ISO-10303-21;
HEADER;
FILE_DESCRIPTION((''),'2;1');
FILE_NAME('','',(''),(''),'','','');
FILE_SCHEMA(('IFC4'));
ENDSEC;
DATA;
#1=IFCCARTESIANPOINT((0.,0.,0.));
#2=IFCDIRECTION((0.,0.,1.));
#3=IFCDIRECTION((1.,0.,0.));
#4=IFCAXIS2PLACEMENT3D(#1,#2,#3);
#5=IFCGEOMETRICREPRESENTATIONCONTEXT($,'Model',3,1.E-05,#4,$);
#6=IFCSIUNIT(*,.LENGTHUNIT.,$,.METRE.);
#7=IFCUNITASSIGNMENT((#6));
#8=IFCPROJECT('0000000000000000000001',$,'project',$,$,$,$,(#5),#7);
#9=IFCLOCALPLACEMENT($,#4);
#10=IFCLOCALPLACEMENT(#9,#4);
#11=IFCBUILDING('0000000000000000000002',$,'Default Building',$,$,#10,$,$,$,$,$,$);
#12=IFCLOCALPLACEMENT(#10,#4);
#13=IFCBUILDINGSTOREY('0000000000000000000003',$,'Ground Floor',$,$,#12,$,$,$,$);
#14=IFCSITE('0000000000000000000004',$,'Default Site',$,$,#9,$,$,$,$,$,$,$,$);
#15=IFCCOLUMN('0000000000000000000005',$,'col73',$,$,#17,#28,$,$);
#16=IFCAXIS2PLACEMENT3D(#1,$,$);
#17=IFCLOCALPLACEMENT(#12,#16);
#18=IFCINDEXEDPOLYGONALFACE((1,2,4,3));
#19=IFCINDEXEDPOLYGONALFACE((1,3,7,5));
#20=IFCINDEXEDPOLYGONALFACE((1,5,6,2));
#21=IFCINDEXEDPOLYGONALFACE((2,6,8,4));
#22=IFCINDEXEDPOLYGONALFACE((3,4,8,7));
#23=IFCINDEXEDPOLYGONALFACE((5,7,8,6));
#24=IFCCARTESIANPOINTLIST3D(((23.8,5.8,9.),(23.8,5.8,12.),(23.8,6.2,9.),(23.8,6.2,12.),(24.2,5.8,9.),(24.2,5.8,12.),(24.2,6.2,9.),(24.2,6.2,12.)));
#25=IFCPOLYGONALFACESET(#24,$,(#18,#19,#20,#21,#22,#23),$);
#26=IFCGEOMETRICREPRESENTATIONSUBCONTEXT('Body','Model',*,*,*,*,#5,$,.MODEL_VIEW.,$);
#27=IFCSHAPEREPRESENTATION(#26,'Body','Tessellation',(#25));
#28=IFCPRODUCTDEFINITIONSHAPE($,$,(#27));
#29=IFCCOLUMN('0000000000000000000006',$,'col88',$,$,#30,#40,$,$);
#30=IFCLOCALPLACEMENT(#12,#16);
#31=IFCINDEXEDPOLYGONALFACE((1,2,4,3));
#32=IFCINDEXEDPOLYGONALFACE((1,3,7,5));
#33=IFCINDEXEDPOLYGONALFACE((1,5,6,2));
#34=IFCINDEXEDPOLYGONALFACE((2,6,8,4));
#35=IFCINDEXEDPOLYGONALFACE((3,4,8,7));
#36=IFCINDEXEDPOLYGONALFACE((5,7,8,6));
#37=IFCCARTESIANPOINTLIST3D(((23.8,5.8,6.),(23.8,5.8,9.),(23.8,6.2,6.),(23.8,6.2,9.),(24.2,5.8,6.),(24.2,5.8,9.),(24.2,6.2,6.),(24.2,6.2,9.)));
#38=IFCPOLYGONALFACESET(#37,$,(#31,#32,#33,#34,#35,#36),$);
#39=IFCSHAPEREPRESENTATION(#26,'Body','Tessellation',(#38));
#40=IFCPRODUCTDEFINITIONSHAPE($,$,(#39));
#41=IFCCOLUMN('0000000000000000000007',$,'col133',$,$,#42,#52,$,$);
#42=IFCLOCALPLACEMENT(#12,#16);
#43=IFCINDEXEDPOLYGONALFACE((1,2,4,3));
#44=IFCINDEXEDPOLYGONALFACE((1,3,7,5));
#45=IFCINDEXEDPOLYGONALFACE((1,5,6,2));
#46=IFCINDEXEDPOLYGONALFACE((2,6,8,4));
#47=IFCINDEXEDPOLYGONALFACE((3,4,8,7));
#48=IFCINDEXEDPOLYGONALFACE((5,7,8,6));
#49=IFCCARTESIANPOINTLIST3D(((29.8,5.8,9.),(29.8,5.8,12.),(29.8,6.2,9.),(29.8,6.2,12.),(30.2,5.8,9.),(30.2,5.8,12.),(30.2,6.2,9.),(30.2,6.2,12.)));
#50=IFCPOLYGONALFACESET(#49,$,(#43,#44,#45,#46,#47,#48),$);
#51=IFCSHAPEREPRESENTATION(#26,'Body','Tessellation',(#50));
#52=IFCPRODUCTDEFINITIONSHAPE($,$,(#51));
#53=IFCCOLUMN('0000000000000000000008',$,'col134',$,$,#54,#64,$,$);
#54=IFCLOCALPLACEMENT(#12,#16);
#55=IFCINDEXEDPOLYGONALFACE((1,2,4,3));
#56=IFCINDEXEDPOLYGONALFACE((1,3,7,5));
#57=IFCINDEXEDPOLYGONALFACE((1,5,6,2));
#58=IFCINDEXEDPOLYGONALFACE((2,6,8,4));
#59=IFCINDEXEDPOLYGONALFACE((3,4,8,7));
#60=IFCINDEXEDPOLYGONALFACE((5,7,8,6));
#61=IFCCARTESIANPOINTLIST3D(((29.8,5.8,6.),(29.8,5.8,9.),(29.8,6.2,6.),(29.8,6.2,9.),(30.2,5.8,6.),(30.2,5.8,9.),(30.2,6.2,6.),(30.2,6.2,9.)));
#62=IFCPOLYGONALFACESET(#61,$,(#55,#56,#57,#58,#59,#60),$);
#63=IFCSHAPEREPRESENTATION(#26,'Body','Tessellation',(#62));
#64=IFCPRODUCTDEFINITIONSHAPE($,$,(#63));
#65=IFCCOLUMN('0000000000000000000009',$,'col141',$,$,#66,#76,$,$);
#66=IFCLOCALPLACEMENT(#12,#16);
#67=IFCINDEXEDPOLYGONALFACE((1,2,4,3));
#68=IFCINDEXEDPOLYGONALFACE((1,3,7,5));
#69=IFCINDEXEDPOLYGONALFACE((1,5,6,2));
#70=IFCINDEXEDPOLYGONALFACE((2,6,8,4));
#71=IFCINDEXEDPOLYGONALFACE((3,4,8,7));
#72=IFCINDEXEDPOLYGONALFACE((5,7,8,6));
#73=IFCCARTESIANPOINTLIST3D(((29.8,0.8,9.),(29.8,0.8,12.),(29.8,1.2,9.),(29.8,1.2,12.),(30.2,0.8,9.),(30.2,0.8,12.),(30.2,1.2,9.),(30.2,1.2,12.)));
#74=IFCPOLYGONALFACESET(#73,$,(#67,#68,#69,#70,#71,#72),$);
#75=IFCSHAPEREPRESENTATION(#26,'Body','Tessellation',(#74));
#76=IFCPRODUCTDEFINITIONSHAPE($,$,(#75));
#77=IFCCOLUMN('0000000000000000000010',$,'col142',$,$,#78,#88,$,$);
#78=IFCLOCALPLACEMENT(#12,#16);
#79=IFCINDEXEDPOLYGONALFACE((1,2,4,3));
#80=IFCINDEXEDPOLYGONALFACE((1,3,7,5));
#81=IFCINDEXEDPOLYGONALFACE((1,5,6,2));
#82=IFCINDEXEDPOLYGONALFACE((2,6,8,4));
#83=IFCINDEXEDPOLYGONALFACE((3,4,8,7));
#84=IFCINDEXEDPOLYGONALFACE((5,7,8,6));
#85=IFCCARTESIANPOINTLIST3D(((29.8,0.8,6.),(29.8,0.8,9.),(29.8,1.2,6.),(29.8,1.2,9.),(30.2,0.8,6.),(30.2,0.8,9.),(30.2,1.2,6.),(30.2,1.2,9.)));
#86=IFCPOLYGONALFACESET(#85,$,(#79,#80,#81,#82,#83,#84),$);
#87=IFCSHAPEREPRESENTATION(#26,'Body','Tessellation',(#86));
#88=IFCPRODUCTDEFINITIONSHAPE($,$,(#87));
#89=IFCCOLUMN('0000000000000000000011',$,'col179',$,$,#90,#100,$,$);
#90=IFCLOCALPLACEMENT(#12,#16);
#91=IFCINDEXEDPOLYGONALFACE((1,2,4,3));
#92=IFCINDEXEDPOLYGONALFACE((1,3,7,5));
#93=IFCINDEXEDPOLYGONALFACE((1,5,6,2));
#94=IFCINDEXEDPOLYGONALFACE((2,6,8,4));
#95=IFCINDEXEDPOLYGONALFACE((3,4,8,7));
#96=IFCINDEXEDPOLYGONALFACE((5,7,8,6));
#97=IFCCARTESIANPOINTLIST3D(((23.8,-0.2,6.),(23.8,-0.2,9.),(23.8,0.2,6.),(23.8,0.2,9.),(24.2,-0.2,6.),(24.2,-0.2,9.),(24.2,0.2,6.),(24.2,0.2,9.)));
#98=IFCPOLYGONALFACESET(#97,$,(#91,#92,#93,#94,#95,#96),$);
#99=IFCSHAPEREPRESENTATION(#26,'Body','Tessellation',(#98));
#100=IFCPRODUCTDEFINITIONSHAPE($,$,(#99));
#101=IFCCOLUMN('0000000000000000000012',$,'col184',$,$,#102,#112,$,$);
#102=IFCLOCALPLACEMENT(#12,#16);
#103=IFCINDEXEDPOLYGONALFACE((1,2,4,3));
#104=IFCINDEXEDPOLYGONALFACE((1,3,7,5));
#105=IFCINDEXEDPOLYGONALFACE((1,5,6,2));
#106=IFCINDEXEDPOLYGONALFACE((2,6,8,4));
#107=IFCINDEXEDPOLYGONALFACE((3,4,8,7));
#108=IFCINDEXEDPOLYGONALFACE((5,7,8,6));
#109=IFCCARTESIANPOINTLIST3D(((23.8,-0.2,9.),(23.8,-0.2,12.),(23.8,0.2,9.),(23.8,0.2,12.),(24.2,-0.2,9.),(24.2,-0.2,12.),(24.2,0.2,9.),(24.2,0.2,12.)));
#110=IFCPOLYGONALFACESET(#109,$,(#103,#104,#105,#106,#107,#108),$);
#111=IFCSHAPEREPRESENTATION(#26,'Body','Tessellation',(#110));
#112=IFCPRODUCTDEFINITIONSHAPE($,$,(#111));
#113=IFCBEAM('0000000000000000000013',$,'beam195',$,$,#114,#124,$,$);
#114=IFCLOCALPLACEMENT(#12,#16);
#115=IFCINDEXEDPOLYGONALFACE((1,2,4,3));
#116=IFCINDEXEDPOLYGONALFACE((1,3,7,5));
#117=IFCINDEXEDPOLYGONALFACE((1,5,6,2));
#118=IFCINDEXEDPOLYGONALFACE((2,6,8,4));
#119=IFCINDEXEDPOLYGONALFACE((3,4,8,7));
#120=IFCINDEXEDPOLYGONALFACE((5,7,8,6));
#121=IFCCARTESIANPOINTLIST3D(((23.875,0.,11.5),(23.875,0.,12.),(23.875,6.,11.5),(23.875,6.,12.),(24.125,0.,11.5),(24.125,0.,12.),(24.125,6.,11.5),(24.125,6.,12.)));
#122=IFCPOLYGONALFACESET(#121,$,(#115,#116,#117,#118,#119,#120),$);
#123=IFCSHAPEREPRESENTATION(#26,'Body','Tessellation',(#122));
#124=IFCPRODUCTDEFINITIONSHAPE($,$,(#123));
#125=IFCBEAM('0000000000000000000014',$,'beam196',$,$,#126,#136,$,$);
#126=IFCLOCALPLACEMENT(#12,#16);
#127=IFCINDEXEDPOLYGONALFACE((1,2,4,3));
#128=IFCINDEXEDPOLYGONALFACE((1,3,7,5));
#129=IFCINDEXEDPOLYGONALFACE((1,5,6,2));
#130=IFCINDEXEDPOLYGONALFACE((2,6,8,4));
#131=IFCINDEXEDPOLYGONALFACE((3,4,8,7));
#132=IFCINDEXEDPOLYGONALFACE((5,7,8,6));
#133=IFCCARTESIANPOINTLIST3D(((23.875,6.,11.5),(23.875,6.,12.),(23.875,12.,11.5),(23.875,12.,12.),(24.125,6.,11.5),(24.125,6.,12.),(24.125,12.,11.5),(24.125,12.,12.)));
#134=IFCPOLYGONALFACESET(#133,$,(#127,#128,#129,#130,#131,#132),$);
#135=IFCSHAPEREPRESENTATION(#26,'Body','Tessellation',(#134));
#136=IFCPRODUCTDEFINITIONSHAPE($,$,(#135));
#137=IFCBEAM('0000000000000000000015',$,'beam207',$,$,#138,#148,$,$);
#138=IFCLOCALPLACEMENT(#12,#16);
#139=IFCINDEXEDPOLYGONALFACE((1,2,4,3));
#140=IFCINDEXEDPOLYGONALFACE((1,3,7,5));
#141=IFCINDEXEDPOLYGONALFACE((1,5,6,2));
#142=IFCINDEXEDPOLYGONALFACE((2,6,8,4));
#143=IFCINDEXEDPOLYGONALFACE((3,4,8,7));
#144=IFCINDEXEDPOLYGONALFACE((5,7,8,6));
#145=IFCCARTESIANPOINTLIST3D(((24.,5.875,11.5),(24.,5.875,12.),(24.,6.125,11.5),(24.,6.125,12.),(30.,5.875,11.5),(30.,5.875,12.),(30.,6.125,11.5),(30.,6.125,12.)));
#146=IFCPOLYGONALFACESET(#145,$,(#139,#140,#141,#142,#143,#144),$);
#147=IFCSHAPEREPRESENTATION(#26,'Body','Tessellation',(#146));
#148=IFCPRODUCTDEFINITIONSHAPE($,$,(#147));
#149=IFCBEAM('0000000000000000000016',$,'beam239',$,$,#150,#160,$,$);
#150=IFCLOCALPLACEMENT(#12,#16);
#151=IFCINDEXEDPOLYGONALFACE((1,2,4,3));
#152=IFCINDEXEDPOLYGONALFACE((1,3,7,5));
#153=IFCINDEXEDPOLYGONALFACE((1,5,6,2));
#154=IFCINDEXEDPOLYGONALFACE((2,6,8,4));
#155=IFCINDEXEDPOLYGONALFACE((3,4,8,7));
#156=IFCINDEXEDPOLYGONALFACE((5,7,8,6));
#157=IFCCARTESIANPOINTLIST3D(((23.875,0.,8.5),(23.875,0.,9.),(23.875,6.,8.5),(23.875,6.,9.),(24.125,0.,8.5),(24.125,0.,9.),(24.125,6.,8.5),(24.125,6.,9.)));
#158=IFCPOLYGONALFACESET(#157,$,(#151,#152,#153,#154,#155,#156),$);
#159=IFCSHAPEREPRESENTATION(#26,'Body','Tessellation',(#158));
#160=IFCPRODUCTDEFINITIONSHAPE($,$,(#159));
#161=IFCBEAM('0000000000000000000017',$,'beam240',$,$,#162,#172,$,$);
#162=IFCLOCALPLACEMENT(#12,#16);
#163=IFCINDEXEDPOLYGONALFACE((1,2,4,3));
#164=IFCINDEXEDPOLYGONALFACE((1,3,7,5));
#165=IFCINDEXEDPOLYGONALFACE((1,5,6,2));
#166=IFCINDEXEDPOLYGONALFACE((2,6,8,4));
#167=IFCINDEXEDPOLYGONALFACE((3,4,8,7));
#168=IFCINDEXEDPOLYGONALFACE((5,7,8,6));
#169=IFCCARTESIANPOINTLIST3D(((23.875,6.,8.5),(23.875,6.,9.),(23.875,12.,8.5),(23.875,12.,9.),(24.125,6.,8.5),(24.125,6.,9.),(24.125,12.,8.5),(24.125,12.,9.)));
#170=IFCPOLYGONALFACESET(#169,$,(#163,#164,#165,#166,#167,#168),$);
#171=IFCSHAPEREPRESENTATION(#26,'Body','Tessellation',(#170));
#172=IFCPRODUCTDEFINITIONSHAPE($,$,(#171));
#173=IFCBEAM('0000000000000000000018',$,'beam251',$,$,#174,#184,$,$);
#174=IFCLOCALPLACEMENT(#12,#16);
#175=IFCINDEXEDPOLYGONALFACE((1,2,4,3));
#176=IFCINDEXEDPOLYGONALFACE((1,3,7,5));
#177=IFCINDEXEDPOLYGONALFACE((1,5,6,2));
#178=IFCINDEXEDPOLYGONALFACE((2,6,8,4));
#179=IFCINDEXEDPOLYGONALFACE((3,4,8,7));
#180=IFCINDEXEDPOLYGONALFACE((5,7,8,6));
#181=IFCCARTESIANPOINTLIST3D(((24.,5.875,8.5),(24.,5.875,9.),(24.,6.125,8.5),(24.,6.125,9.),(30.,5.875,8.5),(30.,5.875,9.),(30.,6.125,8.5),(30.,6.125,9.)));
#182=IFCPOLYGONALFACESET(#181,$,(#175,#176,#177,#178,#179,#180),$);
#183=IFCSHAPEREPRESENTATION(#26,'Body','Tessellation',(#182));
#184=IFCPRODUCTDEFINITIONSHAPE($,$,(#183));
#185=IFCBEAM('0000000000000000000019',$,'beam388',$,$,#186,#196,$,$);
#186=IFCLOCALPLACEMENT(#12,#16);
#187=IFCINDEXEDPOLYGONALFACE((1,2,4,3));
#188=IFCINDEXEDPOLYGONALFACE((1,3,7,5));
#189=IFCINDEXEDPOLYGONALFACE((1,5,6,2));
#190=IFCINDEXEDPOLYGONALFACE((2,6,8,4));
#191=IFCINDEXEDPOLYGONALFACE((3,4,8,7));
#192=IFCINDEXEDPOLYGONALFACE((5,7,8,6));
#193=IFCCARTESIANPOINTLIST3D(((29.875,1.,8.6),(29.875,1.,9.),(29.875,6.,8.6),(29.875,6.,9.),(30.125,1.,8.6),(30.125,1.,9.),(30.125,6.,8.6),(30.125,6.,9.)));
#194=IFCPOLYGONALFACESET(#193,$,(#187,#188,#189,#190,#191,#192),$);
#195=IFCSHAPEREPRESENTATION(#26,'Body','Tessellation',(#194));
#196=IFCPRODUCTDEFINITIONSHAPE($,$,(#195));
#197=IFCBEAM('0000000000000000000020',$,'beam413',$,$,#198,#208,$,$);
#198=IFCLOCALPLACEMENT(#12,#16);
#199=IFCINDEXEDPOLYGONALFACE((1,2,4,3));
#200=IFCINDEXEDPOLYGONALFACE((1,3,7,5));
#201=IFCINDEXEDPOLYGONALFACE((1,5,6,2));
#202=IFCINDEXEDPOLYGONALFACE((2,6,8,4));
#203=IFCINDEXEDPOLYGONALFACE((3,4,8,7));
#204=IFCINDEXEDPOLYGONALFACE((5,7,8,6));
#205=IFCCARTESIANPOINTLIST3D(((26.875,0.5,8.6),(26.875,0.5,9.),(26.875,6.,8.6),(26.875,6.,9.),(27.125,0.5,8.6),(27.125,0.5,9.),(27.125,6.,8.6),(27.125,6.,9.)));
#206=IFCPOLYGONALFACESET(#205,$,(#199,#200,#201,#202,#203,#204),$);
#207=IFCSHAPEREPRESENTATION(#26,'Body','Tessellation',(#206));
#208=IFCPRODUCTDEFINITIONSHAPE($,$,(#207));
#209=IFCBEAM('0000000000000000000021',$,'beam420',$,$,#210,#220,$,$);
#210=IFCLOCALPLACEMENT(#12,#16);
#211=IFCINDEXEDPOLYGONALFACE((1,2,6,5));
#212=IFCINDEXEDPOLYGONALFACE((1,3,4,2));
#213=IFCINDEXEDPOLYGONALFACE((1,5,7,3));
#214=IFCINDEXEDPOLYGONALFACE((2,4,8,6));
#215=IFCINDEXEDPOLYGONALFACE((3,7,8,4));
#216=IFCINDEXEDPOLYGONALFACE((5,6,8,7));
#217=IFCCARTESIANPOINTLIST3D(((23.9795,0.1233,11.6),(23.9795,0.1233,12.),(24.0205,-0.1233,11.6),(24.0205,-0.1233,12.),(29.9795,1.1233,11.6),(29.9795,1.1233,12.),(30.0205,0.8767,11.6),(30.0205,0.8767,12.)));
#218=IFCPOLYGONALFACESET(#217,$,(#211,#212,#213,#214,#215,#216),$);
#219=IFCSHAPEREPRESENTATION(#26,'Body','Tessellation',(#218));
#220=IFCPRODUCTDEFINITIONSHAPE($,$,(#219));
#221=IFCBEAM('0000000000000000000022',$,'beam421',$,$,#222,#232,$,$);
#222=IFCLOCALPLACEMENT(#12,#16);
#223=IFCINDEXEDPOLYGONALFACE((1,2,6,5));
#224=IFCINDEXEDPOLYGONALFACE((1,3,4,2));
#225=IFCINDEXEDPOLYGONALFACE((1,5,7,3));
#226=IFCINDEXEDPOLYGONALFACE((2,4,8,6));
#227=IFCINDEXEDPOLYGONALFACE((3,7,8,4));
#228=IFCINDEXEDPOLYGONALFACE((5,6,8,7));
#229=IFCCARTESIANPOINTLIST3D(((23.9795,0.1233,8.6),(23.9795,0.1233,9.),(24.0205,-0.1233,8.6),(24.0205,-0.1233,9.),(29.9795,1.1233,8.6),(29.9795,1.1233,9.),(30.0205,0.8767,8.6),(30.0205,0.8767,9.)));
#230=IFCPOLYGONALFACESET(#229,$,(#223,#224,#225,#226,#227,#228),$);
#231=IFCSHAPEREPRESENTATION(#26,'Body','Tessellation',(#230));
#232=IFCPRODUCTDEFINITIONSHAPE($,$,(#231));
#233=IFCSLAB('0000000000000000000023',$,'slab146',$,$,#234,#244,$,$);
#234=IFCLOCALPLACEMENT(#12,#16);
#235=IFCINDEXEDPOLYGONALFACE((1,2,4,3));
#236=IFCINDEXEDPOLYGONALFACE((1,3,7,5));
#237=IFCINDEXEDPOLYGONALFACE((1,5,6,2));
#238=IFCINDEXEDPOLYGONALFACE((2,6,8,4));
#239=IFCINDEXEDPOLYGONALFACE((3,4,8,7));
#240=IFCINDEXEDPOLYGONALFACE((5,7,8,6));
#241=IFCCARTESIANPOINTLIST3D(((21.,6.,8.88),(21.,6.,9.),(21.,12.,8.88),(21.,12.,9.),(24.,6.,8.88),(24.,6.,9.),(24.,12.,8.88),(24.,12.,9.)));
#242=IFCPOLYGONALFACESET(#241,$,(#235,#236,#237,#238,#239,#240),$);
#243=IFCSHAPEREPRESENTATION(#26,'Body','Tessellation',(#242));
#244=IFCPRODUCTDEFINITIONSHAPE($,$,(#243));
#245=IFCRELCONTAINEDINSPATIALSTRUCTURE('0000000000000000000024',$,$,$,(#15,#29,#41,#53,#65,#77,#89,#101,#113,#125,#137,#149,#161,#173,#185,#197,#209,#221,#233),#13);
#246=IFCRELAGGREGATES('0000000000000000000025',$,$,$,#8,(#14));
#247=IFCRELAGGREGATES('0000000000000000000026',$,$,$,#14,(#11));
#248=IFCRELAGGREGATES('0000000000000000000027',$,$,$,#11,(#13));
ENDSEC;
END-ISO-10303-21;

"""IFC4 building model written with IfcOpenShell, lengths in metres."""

from ifc_helpers import new_model, si_unit, frame, origin_with_axes, place, context, subcontext, project, spatial, indexed_curve, outline, extrude, element, save


model = new_model("IFC4")

# Units and contexts
model_context = context("Model", 3, precision=1e-05, world=origin_with_axes())
body_context = subcontext(model_context, "Body", "Model", "MODEL_VIEW")
ifc_project = project(units=[si_unit("LENGTHUNIT", "METRE")], contexts=[model_context])

# Site, building, storey
site_placement = place(None, origin_with_axes())
site = spatial("IfcSite", under=ifc_project, at=site_placement, Name="Default Site")
building_placement = place(site_placement, origin_with_axes())
building = spatial("IfcBuilding", under=site, at=building_placement, Name="Default Building")
storey_placement = place(building_placement, origin_with_axes())
storey = spatial("IfcBuildingStorey", under=building, at=storey_placement, Name="Ground Floor")

# Columns
for number, where, z_axis, x_axis, name in (
    (1, (23.8, 5.8, 9.0), (0.0, 0.0, 1.0), (1.0, 0.0, 0.0), "col73"),
    (2, (23.8, 5.8, 6.0), (0.0, 0.0, 1.0), (1.0, 0.0, 0.0), "col88"),
    (3, (29.8, 5.8, 9.0), (0.0, 0.0, 1.0), (1.0, 0.0, 0.0), "col133"),
    (4, (29.8, 5.8, 6.0), (0.0, 0.0, 1.0), (1.0, 0.0, 0.0), "col134"),
    (5, (29.8, 0.8, 9.0), (0.0, 0.0, 1.0), (1.0, 0.0, 0.0), "col141"),
    (6, (29.8, 0.8, 6.0), (0.0, 0.0, 1.0), (1.0, 0.0, 0.0), "col142"),
    (7, (23.8, -0.2, 6.0), (0.0, 0.0, 1.0), (1.0, 0.0, 0.0), "col179"),
    (8, (23.8, -0.2, 9.0), (0.0, 0.0, 1.0), (1.0, 0.0, 0.0), "col184"),
):
    element("IfcColumn", number, at=place(storey_placement, frame(where, z_axis=z_axis, x_axis=x_axis)), inside=storey, Name=name, context=body_context, shape_type="SweptSolid", body=[
        extrude(outline(indexed_curve([(0.0, 0.0), (0.0, 0.4), (0.4, 0.4), (0.4, 0.0), (0.0, 0.0)], self_intersect=False)), origin_with_axes(), (0.0, 0.0, 1.0), 3.0),
    ])

# Beams
for number, where, z_axis, x_axis, name in (
    (9, (24.125, 0.0, 11.5), (0.0, 0.0, 1.0), (0.0, 1.0, 0.0), "beam195"),
    (10, (24.125, 6.0, 11.5), (0.0, 0.0, 1.0), (0.0, 1.0, 0.0), "beam196"),
    (11, (24.0, 5.875, 11.5), (0.0, 0.0, 1.0), (1.0, 0.0, 0.0), "beam207"),
    (12, (24.125, 0.0, 8.5), (0.0, 0.0, 1.0), (0.0, 1.0, 0.0), "beam239"),
    (13, (24.125, 6.0, 8.5), (0.0, 0.0, 1.0), (0.0, 1.0, 0.0), "beam240"),
    (14, (24.0, 5.875, 8.5), (0.0, 0.0, 1.0), (1.0, 0.0, 0.0), "beam251"),
):
    element("IfcBeam", number, at=place(storey_placement, frame(where, z_axis=z_axis, x_axis=x_axis)), inside=storey, Name=name, context=body_context, shape_type="SweptSolid", body=[
        extrude(outline(indexed_curve([(0.0, 0.0), (0.0, 0.25), (6.0, 0.25), (6.0, 0.0), (0.0, 0.0)], self_intersect=False)), origin_with_axes(), (0.0, 0.0, 1.0), 0.5),
    ])
beam_1_placement = place(storey_placement, frame((29.875, 6.0, 8.6), z_axis=(0.0, 0.0, 1.0), x_axis=(0.0, -1.0, 0.0)))
element("IfcBeam", 15, at=beam_1_placement, inside=storey, Name="beam388", context=body_context, shape_type="SweptSolid", body=[
    extrude(outline(indexed_curve([(0.0, 0.0), (0.0, 0.25), (5.0, 0.25), (5.0, 0.0), (0.0, 0.0)], self_intersect=False)), origin_with_axes(), (0.0, 0.0, 1.0), 0.4),
])
beam_2_placement = place(storey_placement, frame((26.875, 6.0, 8.6), z_axis=(0.0, 0.0, 1.0), x_axis=(0.0, -1.0, 0.0)))
element("IfcBeam", 16, at=beam_2_placement, inside=storey, Name="beam413", context=body_context, shape_type="SweptSolid", body=[
    extrude(outline(indexed_curve([(0.0, 0.0), (0.0, 0.25), (5.5, 0.25), (5.5, 0.0), (0.0, 0.0)], self_intersect=False)), origin_with_axes(), (0.0, 0.0, 1.0), 0.4),
])
for number, where, z_axis, x_axis, name in (
    (17, (24.0205, -0.1233, 11.6), (0.0, 0.0, 1.0), (0.986394, 0.164399, 0.0), "beam420"),
    (18, (24.0205, -0.1233, 8.6), (0.0, 0.0, 1.0), (0.986394, 0.164399, 0.0), "beam421"),
):
    element("IfcBeam", number, at=place(storey_placement, frame(where, z_axis=z_axis, x_axis=x_axis)), inside=storey, Name=name, context=body_context, shape_type="SweptSolid", body=[
        extrude(outline(indexed_curve([(0.0, 0.0), (0.0, 0.25), (6.0828, 0.25), (6.0828, 0.0), (0.0, 0.0)], self_intersect=False)), origin_with_axes(), (0.0, 0.0, 1.0), 0.4),
    ])

# Slab
for number, where, z_axis, x_axis, name in (
    (19, (21.0, 6.0, 8.88), (0.0, 0.0, 1.0), (1.0, 0.0, 0.0), "slab146"),
):
    element("IfcSlab", number, at=place(storey_placement, frame(where, z_axis=z_axis, x_axis=x_axis)), inside=storey, Name=name, context=body_context, shape_type="SweptSolid", body=[
        extrude(outline(indexed_curve([(0.0, 0.0), (0.0, 6.0), (3.0, 6.0), (3.0, 0.0), (0.0, 0.0)], self_intersect=False)), origin_with_axes(), (0.0, 0.0, 1.0), 0.12),
    ])

save(model, "model.ifc")
